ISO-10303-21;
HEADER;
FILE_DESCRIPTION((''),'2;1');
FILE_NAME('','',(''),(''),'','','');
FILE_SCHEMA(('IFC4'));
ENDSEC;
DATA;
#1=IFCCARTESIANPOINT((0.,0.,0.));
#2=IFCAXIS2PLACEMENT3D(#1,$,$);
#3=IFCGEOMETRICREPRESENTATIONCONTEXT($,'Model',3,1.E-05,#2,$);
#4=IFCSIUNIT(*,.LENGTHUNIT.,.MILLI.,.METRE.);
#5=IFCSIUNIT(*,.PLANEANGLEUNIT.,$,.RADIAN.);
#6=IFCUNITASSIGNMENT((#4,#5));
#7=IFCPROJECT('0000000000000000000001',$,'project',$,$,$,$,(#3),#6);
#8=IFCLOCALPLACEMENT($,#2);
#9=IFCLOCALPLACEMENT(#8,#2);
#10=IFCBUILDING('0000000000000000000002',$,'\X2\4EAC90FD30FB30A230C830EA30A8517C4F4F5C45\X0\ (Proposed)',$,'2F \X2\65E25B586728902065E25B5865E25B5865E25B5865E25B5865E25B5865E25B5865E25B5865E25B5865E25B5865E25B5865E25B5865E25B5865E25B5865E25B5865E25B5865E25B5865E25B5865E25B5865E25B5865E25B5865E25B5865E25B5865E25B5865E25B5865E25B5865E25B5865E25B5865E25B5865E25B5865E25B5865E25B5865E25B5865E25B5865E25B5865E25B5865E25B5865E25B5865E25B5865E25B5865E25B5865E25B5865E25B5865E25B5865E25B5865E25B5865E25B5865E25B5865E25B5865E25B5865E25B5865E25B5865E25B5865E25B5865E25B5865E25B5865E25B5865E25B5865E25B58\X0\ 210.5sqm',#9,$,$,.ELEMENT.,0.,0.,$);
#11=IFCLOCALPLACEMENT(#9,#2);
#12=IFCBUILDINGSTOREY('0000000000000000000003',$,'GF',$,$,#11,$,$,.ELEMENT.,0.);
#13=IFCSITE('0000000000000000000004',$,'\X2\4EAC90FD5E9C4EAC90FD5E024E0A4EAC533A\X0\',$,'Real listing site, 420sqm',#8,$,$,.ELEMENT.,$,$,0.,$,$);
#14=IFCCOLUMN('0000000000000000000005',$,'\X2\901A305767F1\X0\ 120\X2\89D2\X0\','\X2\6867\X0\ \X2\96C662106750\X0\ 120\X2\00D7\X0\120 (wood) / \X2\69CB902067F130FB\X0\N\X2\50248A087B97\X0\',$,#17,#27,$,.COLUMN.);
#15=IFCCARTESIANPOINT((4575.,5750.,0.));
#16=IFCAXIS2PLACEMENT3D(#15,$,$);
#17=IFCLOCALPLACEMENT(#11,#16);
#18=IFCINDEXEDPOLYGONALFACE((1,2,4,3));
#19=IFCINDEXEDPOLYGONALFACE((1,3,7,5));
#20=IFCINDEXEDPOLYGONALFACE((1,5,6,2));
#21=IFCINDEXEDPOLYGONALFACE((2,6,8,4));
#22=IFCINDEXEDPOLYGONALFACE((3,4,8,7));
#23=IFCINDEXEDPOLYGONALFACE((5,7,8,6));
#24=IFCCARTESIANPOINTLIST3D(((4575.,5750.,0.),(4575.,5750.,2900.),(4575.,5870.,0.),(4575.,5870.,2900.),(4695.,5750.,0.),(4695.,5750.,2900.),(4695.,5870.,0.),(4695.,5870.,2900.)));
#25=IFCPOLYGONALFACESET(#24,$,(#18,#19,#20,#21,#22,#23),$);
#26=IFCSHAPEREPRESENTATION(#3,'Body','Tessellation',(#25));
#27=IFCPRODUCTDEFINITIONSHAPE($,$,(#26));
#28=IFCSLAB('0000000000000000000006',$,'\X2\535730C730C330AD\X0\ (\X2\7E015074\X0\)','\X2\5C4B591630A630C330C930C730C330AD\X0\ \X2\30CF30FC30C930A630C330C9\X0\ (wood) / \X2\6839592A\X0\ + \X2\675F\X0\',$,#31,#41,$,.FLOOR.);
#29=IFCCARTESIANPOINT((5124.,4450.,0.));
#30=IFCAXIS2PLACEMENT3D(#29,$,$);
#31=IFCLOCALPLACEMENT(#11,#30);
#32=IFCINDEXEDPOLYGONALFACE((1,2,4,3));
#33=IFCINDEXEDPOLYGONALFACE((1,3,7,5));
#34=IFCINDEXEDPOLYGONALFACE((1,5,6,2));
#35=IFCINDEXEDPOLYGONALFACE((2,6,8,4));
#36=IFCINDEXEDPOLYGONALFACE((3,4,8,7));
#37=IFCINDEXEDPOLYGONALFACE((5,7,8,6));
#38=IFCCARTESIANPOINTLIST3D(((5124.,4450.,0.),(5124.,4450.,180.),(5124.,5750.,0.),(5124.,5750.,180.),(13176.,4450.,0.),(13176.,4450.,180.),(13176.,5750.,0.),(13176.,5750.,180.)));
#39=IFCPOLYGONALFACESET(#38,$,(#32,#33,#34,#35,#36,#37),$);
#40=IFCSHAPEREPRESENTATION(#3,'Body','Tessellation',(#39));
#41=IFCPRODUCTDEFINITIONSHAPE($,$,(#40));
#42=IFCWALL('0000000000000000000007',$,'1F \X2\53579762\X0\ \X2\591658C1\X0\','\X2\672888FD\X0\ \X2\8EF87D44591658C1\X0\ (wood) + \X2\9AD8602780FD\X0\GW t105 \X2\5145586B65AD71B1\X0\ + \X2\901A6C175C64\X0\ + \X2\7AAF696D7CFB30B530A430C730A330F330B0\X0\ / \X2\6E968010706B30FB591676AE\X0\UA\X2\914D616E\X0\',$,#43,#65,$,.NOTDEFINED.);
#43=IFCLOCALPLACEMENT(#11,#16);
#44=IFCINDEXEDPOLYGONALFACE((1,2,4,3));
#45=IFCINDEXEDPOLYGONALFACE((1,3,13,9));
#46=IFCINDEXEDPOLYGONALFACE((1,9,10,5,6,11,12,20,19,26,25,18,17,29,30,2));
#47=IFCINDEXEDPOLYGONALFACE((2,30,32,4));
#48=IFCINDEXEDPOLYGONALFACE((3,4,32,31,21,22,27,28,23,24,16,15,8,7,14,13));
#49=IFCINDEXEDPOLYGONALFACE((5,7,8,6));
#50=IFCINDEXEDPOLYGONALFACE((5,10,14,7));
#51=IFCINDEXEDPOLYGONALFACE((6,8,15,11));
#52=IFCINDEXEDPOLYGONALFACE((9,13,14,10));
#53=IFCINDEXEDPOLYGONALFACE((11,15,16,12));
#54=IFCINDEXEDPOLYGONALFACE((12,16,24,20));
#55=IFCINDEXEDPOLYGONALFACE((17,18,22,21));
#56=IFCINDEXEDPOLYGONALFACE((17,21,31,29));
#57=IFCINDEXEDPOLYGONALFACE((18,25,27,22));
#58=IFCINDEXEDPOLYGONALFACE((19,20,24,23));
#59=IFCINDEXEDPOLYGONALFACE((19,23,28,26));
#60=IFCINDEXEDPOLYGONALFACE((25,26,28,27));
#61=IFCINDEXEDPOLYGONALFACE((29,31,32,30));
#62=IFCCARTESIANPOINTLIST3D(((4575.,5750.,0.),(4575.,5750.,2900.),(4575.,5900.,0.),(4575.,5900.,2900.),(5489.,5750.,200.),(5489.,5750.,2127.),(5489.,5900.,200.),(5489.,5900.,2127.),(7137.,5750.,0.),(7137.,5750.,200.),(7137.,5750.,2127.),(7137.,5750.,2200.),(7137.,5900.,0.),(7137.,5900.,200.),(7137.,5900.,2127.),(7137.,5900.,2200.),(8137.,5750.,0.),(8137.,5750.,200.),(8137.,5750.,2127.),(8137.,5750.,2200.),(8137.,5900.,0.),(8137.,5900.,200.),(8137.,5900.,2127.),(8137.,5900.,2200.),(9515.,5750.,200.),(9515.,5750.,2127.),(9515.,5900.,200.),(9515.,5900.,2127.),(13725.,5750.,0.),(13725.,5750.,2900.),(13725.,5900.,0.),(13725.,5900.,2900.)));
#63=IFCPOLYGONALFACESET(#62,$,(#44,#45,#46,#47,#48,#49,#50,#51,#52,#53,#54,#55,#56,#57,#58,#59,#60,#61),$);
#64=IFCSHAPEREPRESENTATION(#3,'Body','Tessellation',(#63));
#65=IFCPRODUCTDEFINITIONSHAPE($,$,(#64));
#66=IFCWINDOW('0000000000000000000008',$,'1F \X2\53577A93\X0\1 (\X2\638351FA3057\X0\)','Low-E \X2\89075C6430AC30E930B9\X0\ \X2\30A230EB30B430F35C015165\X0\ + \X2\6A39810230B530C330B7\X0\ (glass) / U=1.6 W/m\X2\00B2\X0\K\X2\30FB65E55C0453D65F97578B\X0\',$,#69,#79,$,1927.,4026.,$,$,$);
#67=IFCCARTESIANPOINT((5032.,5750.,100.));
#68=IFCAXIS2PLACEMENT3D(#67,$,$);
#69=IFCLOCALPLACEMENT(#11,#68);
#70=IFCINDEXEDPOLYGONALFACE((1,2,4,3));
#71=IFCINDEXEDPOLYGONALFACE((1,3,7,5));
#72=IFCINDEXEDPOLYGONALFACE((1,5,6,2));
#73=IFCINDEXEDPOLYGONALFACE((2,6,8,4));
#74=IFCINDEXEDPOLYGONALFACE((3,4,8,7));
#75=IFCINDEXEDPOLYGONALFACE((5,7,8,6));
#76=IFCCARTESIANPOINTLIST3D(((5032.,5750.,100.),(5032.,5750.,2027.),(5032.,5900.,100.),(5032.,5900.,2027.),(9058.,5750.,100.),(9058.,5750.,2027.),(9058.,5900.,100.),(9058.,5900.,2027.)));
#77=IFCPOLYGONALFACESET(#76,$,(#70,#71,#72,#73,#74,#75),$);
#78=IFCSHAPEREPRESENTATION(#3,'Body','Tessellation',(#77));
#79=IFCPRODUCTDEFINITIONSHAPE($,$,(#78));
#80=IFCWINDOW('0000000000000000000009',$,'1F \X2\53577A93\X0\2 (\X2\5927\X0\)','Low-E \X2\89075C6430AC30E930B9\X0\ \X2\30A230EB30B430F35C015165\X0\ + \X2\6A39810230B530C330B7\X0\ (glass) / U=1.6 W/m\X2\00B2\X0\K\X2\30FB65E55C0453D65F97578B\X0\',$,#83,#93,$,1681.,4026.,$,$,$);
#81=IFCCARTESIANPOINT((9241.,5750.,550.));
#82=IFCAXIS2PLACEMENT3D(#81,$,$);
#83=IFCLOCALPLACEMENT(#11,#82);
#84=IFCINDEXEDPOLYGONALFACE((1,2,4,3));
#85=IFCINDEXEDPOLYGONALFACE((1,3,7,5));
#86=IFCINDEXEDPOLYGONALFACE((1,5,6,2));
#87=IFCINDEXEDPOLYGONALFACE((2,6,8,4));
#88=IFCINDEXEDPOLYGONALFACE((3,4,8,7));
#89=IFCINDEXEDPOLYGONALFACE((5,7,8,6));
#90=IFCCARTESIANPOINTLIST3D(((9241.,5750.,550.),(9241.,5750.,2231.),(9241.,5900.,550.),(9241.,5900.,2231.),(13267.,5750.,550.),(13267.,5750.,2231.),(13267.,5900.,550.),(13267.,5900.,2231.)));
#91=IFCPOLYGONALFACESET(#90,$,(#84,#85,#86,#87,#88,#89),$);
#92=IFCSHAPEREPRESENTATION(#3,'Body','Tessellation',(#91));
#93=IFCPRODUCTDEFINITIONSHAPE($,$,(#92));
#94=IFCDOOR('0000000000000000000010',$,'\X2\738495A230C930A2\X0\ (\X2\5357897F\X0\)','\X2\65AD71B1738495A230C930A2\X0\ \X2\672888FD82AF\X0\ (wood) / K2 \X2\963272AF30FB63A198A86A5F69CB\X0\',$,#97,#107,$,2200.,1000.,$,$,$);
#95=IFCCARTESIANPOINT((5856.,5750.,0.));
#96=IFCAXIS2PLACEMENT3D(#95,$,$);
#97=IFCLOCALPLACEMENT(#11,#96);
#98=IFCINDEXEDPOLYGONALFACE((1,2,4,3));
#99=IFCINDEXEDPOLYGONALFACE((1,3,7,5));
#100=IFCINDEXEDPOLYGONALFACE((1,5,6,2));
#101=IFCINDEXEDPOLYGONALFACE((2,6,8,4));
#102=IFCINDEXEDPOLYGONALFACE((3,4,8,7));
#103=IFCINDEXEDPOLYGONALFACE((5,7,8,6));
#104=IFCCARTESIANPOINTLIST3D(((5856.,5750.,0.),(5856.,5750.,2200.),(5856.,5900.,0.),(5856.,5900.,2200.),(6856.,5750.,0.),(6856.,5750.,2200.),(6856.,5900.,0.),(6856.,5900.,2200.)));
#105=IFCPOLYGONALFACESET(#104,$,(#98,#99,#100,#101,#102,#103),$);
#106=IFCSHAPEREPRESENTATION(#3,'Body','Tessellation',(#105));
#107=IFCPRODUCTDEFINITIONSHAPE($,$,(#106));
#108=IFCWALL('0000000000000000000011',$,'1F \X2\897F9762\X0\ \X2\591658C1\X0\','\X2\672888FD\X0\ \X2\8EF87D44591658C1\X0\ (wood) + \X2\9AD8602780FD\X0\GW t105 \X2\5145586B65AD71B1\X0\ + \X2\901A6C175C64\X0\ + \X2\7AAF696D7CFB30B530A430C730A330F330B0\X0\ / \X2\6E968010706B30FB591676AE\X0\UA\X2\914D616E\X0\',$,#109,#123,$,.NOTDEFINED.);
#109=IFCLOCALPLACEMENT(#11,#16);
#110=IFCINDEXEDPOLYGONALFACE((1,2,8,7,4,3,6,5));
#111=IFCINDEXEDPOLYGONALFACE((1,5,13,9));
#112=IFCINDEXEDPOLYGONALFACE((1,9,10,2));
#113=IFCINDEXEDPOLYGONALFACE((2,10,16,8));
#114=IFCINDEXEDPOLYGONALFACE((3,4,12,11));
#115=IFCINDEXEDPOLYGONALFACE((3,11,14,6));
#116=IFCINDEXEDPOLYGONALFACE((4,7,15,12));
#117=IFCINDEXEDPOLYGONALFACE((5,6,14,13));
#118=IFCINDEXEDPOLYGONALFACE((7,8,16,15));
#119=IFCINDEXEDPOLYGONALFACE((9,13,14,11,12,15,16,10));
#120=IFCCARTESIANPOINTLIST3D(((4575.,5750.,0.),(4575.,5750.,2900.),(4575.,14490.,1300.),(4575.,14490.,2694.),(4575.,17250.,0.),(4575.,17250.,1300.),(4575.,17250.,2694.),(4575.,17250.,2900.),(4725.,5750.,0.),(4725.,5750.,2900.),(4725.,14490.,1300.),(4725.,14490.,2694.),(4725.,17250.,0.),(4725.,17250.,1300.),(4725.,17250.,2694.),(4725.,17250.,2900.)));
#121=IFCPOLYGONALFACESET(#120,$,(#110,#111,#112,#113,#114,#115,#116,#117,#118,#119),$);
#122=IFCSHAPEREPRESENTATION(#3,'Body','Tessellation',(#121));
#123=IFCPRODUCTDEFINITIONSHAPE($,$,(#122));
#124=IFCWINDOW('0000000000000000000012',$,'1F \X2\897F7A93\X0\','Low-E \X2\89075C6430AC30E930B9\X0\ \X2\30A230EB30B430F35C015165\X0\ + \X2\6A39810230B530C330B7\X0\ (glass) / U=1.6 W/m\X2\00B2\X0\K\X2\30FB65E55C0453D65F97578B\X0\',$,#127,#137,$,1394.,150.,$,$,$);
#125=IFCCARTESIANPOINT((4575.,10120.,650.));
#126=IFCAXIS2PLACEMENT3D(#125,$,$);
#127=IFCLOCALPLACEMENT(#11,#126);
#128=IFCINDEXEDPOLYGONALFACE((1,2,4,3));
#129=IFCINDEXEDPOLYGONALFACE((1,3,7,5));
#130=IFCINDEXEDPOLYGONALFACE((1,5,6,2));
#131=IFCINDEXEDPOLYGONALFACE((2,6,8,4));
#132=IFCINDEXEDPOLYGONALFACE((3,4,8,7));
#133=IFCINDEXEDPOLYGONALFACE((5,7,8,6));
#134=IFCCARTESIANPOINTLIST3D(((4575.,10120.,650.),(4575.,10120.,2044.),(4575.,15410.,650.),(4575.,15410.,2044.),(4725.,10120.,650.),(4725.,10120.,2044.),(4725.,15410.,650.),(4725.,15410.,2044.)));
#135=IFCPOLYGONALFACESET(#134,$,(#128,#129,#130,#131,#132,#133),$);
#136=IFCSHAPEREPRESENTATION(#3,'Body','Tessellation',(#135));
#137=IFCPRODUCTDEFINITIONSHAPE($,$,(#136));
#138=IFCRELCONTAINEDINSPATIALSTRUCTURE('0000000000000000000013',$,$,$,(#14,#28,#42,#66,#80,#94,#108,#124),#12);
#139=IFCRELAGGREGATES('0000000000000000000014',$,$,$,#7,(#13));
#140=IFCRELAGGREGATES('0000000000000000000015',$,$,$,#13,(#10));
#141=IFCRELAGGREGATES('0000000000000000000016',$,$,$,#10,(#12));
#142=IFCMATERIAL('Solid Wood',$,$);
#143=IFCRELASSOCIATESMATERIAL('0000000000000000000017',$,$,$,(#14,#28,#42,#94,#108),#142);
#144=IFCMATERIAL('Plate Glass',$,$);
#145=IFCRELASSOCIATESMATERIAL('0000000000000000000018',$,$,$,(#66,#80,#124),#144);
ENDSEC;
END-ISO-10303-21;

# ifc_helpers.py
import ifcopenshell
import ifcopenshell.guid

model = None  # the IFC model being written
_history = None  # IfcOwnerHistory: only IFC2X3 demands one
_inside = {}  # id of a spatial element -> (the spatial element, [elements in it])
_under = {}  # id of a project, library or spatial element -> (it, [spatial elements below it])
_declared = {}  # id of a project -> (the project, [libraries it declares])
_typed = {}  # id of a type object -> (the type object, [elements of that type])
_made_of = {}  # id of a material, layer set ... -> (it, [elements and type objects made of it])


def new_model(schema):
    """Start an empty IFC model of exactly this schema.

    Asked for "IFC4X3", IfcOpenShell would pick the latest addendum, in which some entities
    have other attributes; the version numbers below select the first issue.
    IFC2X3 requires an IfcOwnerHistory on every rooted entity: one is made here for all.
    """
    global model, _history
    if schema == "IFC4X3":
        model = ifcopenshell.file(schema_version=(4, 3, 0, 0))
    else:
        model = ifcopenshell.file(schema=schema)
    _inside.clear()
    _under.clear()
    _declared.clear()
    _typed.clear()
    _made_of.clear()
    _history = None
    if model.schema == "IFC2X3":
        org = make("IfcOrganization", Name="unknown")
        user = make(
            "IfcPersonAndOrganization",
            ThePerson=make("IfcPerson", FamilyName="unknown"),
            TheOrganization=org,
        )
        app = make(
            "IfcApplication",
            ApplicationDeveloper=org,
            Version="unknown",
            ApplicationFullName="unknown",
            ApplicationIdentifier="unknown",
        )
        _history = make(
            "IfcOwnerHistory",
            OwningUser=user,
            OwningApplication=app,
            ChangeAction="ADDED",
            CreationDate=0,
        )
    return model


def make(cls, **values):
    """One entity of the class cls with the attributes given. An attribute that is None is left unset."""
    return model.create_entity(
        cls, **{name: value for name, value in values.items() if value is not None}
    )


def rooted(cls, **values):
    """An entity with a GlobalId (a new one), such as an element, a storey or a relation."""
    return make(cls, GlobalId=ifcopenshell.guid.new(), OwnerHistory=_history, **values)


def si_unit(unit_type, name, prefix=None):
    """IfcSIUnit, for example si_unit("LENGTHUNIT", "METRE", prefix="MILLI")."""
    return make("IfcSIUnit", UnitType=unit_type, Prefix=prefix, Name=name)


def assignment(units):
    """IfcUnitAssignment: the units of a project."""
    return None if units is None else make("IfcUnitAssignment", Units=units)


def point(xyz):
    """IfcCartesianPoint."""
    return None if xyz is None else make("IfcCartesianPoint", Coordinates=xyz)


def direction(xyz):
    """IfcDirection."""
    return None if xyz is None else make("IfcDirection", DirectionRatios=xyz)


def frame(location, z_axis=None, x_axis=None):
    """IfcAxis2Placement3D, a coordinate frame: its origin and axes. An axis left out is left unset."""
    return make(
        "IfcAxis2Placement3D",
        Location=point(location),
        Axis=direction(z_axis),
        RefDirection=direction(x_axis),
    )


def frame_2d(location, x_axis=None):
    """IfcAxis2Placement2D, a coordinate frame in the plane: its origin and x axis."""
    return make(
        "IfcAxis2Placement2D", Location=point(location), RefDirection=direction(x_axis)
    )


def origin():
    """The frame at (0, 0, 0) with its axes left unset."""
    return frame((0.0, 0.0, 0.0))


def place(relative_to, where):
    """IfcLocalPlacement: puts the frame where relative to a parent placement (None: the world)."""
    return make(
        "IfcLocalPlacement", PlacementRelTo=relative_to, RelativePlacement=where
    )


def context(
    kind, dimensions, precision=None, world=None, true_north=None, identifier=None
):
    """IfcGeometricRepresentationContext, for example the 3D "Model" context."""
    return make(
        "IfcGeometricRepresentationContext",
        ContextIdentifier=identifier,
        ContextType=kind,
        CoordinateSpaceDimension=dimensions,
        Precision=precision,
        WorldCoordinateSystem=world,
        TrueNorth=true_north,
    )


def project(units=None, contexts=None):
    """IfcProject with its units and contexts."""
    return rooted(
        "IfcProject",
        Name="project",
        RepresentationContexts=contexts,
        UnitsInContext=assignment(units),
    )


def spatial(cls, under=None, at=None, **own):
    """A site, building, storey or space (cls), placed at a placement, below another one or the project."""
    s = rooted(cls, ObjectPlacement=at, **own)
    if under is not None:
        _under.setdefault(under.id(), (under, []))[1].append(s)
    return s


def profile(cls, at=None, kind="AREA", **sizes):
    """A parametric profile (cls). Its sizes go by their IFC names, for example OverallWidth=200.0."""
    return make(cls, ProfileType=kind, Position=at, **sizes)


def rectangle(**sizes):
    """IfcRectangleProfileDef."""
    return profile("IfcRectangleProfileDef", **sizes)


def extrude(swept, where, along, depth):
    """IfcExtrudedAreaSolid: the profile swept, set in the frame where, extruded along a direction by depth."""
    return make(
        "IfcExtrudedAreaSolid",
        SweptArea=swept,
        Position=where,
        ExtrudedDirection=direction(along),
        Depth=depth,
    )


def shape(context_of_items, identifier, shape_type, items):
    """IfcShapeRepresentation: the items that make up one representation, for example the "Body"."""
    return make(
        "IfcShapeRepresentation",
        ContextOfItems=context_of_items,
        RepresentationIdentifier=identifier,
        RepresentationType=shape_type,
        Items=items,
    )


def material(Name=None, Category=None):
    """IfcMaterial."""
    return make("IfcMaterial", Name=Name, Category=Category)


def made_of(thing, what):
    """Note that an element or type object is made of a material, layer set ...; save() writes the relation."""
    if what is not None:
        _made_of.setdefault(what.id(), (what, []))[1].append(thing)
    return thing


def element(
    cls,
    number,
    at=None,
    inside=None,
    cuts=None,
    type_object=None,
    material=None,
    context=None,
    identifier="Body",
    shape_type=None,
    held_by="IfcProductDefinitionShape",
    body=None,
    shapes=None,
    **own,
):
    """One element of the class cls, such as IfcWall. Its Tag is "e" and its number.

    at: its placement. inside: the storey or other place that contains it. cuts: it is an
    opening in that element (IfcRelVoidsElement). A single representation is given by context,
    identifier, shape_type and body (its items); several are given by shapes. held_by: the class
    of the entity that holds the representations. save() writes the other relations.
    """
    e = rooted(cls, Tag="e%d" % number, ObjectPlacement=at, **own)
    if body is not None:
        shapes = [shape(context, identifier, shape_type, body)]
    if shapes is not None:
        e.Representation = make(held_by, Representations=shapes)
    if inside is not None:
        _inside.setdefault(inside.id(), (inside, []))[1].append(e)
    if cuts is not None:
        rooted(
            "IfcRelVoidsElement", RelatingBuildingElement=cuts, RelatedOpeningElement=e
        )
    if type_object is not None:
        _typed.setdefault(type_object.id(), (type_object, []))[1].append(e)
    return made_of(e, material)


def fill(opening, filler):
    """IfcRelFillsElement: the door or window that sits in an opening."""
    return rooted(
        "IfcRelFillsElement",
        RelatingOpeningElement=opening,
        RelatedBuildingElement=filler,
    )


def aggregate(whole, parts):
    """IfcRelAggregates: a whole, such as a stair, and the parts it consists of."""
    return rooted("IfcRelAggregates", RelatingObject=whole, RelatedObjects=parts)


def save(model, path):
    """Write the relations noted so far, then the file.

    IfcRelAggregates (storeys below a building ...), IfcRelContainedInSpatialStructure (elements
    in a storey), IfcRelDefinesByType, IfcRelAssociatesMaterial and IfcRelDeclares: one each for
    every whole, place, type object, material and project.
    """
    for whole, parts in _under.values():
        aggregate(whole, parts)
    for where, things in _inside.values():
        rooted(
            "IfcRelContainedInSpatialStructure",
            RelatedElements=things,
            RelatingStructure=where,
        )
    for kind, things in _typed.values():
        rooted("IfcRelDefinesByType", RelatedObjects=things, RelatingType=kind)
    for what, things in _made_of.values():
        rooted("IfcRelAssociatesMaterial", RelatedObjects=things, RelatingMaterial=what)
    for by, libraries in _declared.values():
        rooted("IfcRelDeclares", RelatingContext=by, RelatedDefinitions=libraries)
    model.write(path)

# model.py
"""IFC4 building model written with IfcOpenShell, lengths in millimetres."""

from ifc_helpers import new_model, si_unit, frame, frame_2d, origin, place, context, project, spatial, rectangle, extrude, material, element, fill, save


model = new_model("IFC4")

# Units and contexts
model_context = context("Model", 3, precision=1e-05, world=origin())
ifc_project = project(units=[si_unit("LENGTHUNIT", "METRE", prefix="MILLI"), si_unit("PLANEANGLEUNIT", "RADIAN")], contexts=[model_context])

# Site, building, storey
site_placement = place(None, origin())
site = spatial("IfcSite", under=ifc_project, at=site_placement, Name="京都府京都市上京区", ObjectType="Real listing site, 420sqm", CompositionType="ELEMENT", RefElevation=0.0)
building_placement = place(site_placement, origin())
building = spatial("IfcBuilding", under=site, at=building_placement, Name="京都・アトリエ兼住居 (Proposed)", ObjectType="2F 既存木造既存既存既存既存既存既存既存既存既存既存既存既存既存既存既存既存既存既存既存既存既存既存既存既存既存既存既存既存既存既存既存既存既存既存既存既存既存既存既存既存既存既存既存既存既存既存既存既存既存既存既存既存既存既存既存既存既存既存 210.5sqm", CompositionType="ELEMENT", ElevationOfRefHeight=0.0, ElevationOfTerrain=0.0)
storey_placement = place(building_placement, origin())
storey = spatial("IfcBuildingStorey", under=building, at=storey_placement, Name="GF", CompositionType="ELEMENT", Elevation=0.0)

# Column
ifc_material_1 = material(Name="Solid Wood")
column_placement = place(storey_placement, frame((4575.0, 5750.0, 0.0)))
element("IfcColumn", 1, at=column_placement, inside=storey, material=ifc_material_1, Name="通し柱 120角", Description="桧 集成材 120×120 (wood) / 構造柱・N値計算", PredefinedType="COLUMN", context=model_context, shape_type="SweptSolid", body=[
    extrude(rectangle(XDim=120.0, YDim=120.0, at=frame_2d((60.0, 60.0))), frame((4575.0, 5750.0, 0.0)), (0.0, 0.0, 1.0), 2900.0),
])

# Slab
slab_1_placement = place(storey_placement, frame((5124.0, 4450.0, 0.0)))
element("IfcSlab", 2, at=slab_1_placement, inside=storey, material=ifc_material_1, Name="南デッキ (縁側)", Description="屋外ウッドデッキ ハードウッド (wood) / 根太 + 束", PredefinedType="FLOOR", context=model_context, shape_type="SweptSolid", body=[
    extrude(rectangle(XDim=8052.0, YDim=1300.0, at=frame_2d((4026.0, 650.0))), frame((5124.0, 4450.0, 0.0)), (0.0, 0.0, 1.0), 180.0),
])

# Wall, openings, windows, door
wall_1_placement = place(storey_placement, frame((4575.0, 5750.0, 0.0)))
wall_1 = element("IfcWall", 3, at=wall_1_placement, inside=storey, material=ifc_material_1, Name="1F 南面 外壁", Description="木製 軸組外壁 (wood) + 高性能GW t105 充填断熱 + 通気層 + 窯業系サイディング / 準耐火・外皮UA配慮", PredefinedType="NOTDEFINED", context=model_context, shape_type="SweptSolid", body=[
    extrude(rectangle(XDim=9150.0, YDim=150.0, at=frame_2d((4575.0, 75.0))), frame((4575.0, 5750.0, 0.0)), (0.0, 0.0, 1.0), 2900.0),
])
opening_1_placement = place(storey_placement, frame((5032.0, 5750.0, 100.0)))
opening_1 = element("IfcOpeningElement", 4, at=opening_1_placement, cuts=wall_1, PredefinedType="NOTDEFINED", context=model_context, shape_type="SweptSolid", body=[
    extrude(rectangle(XDim=4026.0, YDim=150.0, at=frame_2d((2013.0, 75.0))), frame((5032.0, 5750.0, 100.0)), (0.0, 0.0, 1.0), 1927.0),
])
opening_2_placement = place(storey_placement, frame((9241.0, 5750.0, 550.0)))
opening_2 = element("IfcOpeningElement", 5, at=opening_2_placement, cuts=wall_1, PredefinedType="NOTDEFINED", context=model_context, shape_type="SweptSolid", body=[
    extrude(rectangle(XDim=4026.0, YDim=150.0, at=frame_2d((2013.0, 75.0))), frame((9241.0, 5750.0, 550.0)), (0.0, 0.0, 1.0), 1681.0),
])
opening_3_placement = place(storey_placement, frame((5856.0, 5750.0, 0.0)))
opening_3 = element("IfcOpeningElement", 6, at=opening_3_placement, cuts=wall_1, PredefinedType="NOTDEFINED", context=model_context, shape_type="SweptSolid", body=[
    extrude(rectangle(XDim=1000.0, YDim=150.0, at=frame_2d((500.0, 75.0))), frame((5856.0, 5750.0, 0.0)), (0.0, 0.0, 1.0), 2200.0),
])
ifc_material_2 = material(Name="Plate Glass")
window_1_placement = place(storey_placement, frame((5032.0, 5750.0, 100.0)))
window_1 = element("IfcWindow", 7, at=window_1_placement, inside=storey, material=ifc_material_2, Name="1F 南窓1 (掃出し)", Description="Low-E 複層ガラス アルゴン封入 + 樹脂サッシ (glass) / U=1.6 W/m²K・日射取得型", OverallHeight=1927.0, OverallWidth=4026.0, context=model_context, shape_type="SweptSolid", body=[
    extrude(rectangle(XDim=4026.0, YDim=150.0, at=frame_2d((2013.0, 75.0))), frame((5032.0, 5750.0, 100.0)), (0.0, 0.0, 1.0), 1927.0),
])
fill(opening_1, window_1)
window_2_placement = place(storey_placement, frame((9241.0, 5750.0, 550.0)))
window_2 = element("IfcWindow", 8, at=window_2_placement, inside=storey, material=ifc_material_2, Name="1F 南窓2 (大)", Description="Low-E 複層ガラス アルゴン封入 + 樹脂サッシ (glass) / U=1.6 W/m²K・日射取得型", OverallHeight=1681.0, OverallWidth=4026.0, context=model_context, shape_type="SweptSolid", body=[
    extrude(rectangle(XDim=4026.0, YDim=150.0, at=frame_2d((2013.0, 75.0))), frame((9241.0, 5750.0, 550.0)), (0.0, 0.0, 1.0), 1681.0),
])
fill(opening_2, window_2)
door_placement = place(storey_placement, frame((5856.0, 5750.0, 0.0)))
door = element("IfcDoor", 9, at=door_placement, inside=storey, material=ifc_material_1, Name="玄関ドア (南西)", Description="断熱玄関ドア 木製芯 (wood) / K2 防犯・採風機構", OverallHeight=2200.0, OverallWidth=1000.0, context=model_context, shape_type="SweptSolid", body=[
    extrude(rectangle(XDim=1000.0, YDim=150.0, at=frame_2d((500.0, 75.0))), frame((5856.0, 5750.0, 0.0)), (0.0, 0.0, 1.0), 2200.0),
])
fill(opening_3, door)

# Wall, opening, window
wall_2_placement = place(storey_placement, frame((4575.0, 5750.0, 0.0)))
wall_2 = element("IfcWall", 10, at=wall_2_placement, inside=storey, material=ifc_material_1, Name="1F 西面 外壁", Description="木製 軸組外壁 (wood) + 高性能GW t105 充填断熱 + 通気層 + 窯業系サイディング / 準耐火・外皮UA配慮", PredefinedType="NOTDEFINED", context=model_context, shape_type="SweptSolid", body=[
    extrude(rectangle(XDim=150.0, YDim=11500.0, at=frame_2d((75.0, 5750.0))), frame((4575.0, 5750.0, 0.0)), (0.0, 0.0, 1.0), 2900.0),
])
opening_4_placement = place(storey_placement, frame((4575.0, 10120.0, 650.0)))
opening_4 = element("IfcOpeningElement", 11, at=opening_4_placement, cuts=wall_2, PredefinedType="NOTDEFINED", context=model_context, shape_type="SweptSolid", body=[
    extrude(rectangle(XDim=150.0, YDim=5290.0, at=frame_2d((75.0, 2645.0))), frame((4575.0, 10120.0, 650.0)), (0.0, 0.0, 1.0), 1394.0),
])
window_3_placement = place(storey_placement, frame((4575.0, 10120.0, 650.0)))
window_3 = element("IfcWindow", 12, at=window_3_placement, inside=storey, material=ifc_material_2, Name="1F 西窓", Description="Low-E 複層ガラス アルゴン封入 + 樹脂サッシ (glass) / U=1.6 W/m²K・日射取得型", OverallHeight=1394.0, OverallWidth=150.0, context=model_context, shape_type="SweptSolid", body=[
    extrude(rectangle(XDim=150.0, YDim=5290.0, at=frame_2d((75.0, 2645.0))), frame((4575.0, 10120.0, 650.0)), (0.0, 0.0, 1.0), 1394.0),
])
fill(opening_4, window_3)

save(model, "model.ifc")
